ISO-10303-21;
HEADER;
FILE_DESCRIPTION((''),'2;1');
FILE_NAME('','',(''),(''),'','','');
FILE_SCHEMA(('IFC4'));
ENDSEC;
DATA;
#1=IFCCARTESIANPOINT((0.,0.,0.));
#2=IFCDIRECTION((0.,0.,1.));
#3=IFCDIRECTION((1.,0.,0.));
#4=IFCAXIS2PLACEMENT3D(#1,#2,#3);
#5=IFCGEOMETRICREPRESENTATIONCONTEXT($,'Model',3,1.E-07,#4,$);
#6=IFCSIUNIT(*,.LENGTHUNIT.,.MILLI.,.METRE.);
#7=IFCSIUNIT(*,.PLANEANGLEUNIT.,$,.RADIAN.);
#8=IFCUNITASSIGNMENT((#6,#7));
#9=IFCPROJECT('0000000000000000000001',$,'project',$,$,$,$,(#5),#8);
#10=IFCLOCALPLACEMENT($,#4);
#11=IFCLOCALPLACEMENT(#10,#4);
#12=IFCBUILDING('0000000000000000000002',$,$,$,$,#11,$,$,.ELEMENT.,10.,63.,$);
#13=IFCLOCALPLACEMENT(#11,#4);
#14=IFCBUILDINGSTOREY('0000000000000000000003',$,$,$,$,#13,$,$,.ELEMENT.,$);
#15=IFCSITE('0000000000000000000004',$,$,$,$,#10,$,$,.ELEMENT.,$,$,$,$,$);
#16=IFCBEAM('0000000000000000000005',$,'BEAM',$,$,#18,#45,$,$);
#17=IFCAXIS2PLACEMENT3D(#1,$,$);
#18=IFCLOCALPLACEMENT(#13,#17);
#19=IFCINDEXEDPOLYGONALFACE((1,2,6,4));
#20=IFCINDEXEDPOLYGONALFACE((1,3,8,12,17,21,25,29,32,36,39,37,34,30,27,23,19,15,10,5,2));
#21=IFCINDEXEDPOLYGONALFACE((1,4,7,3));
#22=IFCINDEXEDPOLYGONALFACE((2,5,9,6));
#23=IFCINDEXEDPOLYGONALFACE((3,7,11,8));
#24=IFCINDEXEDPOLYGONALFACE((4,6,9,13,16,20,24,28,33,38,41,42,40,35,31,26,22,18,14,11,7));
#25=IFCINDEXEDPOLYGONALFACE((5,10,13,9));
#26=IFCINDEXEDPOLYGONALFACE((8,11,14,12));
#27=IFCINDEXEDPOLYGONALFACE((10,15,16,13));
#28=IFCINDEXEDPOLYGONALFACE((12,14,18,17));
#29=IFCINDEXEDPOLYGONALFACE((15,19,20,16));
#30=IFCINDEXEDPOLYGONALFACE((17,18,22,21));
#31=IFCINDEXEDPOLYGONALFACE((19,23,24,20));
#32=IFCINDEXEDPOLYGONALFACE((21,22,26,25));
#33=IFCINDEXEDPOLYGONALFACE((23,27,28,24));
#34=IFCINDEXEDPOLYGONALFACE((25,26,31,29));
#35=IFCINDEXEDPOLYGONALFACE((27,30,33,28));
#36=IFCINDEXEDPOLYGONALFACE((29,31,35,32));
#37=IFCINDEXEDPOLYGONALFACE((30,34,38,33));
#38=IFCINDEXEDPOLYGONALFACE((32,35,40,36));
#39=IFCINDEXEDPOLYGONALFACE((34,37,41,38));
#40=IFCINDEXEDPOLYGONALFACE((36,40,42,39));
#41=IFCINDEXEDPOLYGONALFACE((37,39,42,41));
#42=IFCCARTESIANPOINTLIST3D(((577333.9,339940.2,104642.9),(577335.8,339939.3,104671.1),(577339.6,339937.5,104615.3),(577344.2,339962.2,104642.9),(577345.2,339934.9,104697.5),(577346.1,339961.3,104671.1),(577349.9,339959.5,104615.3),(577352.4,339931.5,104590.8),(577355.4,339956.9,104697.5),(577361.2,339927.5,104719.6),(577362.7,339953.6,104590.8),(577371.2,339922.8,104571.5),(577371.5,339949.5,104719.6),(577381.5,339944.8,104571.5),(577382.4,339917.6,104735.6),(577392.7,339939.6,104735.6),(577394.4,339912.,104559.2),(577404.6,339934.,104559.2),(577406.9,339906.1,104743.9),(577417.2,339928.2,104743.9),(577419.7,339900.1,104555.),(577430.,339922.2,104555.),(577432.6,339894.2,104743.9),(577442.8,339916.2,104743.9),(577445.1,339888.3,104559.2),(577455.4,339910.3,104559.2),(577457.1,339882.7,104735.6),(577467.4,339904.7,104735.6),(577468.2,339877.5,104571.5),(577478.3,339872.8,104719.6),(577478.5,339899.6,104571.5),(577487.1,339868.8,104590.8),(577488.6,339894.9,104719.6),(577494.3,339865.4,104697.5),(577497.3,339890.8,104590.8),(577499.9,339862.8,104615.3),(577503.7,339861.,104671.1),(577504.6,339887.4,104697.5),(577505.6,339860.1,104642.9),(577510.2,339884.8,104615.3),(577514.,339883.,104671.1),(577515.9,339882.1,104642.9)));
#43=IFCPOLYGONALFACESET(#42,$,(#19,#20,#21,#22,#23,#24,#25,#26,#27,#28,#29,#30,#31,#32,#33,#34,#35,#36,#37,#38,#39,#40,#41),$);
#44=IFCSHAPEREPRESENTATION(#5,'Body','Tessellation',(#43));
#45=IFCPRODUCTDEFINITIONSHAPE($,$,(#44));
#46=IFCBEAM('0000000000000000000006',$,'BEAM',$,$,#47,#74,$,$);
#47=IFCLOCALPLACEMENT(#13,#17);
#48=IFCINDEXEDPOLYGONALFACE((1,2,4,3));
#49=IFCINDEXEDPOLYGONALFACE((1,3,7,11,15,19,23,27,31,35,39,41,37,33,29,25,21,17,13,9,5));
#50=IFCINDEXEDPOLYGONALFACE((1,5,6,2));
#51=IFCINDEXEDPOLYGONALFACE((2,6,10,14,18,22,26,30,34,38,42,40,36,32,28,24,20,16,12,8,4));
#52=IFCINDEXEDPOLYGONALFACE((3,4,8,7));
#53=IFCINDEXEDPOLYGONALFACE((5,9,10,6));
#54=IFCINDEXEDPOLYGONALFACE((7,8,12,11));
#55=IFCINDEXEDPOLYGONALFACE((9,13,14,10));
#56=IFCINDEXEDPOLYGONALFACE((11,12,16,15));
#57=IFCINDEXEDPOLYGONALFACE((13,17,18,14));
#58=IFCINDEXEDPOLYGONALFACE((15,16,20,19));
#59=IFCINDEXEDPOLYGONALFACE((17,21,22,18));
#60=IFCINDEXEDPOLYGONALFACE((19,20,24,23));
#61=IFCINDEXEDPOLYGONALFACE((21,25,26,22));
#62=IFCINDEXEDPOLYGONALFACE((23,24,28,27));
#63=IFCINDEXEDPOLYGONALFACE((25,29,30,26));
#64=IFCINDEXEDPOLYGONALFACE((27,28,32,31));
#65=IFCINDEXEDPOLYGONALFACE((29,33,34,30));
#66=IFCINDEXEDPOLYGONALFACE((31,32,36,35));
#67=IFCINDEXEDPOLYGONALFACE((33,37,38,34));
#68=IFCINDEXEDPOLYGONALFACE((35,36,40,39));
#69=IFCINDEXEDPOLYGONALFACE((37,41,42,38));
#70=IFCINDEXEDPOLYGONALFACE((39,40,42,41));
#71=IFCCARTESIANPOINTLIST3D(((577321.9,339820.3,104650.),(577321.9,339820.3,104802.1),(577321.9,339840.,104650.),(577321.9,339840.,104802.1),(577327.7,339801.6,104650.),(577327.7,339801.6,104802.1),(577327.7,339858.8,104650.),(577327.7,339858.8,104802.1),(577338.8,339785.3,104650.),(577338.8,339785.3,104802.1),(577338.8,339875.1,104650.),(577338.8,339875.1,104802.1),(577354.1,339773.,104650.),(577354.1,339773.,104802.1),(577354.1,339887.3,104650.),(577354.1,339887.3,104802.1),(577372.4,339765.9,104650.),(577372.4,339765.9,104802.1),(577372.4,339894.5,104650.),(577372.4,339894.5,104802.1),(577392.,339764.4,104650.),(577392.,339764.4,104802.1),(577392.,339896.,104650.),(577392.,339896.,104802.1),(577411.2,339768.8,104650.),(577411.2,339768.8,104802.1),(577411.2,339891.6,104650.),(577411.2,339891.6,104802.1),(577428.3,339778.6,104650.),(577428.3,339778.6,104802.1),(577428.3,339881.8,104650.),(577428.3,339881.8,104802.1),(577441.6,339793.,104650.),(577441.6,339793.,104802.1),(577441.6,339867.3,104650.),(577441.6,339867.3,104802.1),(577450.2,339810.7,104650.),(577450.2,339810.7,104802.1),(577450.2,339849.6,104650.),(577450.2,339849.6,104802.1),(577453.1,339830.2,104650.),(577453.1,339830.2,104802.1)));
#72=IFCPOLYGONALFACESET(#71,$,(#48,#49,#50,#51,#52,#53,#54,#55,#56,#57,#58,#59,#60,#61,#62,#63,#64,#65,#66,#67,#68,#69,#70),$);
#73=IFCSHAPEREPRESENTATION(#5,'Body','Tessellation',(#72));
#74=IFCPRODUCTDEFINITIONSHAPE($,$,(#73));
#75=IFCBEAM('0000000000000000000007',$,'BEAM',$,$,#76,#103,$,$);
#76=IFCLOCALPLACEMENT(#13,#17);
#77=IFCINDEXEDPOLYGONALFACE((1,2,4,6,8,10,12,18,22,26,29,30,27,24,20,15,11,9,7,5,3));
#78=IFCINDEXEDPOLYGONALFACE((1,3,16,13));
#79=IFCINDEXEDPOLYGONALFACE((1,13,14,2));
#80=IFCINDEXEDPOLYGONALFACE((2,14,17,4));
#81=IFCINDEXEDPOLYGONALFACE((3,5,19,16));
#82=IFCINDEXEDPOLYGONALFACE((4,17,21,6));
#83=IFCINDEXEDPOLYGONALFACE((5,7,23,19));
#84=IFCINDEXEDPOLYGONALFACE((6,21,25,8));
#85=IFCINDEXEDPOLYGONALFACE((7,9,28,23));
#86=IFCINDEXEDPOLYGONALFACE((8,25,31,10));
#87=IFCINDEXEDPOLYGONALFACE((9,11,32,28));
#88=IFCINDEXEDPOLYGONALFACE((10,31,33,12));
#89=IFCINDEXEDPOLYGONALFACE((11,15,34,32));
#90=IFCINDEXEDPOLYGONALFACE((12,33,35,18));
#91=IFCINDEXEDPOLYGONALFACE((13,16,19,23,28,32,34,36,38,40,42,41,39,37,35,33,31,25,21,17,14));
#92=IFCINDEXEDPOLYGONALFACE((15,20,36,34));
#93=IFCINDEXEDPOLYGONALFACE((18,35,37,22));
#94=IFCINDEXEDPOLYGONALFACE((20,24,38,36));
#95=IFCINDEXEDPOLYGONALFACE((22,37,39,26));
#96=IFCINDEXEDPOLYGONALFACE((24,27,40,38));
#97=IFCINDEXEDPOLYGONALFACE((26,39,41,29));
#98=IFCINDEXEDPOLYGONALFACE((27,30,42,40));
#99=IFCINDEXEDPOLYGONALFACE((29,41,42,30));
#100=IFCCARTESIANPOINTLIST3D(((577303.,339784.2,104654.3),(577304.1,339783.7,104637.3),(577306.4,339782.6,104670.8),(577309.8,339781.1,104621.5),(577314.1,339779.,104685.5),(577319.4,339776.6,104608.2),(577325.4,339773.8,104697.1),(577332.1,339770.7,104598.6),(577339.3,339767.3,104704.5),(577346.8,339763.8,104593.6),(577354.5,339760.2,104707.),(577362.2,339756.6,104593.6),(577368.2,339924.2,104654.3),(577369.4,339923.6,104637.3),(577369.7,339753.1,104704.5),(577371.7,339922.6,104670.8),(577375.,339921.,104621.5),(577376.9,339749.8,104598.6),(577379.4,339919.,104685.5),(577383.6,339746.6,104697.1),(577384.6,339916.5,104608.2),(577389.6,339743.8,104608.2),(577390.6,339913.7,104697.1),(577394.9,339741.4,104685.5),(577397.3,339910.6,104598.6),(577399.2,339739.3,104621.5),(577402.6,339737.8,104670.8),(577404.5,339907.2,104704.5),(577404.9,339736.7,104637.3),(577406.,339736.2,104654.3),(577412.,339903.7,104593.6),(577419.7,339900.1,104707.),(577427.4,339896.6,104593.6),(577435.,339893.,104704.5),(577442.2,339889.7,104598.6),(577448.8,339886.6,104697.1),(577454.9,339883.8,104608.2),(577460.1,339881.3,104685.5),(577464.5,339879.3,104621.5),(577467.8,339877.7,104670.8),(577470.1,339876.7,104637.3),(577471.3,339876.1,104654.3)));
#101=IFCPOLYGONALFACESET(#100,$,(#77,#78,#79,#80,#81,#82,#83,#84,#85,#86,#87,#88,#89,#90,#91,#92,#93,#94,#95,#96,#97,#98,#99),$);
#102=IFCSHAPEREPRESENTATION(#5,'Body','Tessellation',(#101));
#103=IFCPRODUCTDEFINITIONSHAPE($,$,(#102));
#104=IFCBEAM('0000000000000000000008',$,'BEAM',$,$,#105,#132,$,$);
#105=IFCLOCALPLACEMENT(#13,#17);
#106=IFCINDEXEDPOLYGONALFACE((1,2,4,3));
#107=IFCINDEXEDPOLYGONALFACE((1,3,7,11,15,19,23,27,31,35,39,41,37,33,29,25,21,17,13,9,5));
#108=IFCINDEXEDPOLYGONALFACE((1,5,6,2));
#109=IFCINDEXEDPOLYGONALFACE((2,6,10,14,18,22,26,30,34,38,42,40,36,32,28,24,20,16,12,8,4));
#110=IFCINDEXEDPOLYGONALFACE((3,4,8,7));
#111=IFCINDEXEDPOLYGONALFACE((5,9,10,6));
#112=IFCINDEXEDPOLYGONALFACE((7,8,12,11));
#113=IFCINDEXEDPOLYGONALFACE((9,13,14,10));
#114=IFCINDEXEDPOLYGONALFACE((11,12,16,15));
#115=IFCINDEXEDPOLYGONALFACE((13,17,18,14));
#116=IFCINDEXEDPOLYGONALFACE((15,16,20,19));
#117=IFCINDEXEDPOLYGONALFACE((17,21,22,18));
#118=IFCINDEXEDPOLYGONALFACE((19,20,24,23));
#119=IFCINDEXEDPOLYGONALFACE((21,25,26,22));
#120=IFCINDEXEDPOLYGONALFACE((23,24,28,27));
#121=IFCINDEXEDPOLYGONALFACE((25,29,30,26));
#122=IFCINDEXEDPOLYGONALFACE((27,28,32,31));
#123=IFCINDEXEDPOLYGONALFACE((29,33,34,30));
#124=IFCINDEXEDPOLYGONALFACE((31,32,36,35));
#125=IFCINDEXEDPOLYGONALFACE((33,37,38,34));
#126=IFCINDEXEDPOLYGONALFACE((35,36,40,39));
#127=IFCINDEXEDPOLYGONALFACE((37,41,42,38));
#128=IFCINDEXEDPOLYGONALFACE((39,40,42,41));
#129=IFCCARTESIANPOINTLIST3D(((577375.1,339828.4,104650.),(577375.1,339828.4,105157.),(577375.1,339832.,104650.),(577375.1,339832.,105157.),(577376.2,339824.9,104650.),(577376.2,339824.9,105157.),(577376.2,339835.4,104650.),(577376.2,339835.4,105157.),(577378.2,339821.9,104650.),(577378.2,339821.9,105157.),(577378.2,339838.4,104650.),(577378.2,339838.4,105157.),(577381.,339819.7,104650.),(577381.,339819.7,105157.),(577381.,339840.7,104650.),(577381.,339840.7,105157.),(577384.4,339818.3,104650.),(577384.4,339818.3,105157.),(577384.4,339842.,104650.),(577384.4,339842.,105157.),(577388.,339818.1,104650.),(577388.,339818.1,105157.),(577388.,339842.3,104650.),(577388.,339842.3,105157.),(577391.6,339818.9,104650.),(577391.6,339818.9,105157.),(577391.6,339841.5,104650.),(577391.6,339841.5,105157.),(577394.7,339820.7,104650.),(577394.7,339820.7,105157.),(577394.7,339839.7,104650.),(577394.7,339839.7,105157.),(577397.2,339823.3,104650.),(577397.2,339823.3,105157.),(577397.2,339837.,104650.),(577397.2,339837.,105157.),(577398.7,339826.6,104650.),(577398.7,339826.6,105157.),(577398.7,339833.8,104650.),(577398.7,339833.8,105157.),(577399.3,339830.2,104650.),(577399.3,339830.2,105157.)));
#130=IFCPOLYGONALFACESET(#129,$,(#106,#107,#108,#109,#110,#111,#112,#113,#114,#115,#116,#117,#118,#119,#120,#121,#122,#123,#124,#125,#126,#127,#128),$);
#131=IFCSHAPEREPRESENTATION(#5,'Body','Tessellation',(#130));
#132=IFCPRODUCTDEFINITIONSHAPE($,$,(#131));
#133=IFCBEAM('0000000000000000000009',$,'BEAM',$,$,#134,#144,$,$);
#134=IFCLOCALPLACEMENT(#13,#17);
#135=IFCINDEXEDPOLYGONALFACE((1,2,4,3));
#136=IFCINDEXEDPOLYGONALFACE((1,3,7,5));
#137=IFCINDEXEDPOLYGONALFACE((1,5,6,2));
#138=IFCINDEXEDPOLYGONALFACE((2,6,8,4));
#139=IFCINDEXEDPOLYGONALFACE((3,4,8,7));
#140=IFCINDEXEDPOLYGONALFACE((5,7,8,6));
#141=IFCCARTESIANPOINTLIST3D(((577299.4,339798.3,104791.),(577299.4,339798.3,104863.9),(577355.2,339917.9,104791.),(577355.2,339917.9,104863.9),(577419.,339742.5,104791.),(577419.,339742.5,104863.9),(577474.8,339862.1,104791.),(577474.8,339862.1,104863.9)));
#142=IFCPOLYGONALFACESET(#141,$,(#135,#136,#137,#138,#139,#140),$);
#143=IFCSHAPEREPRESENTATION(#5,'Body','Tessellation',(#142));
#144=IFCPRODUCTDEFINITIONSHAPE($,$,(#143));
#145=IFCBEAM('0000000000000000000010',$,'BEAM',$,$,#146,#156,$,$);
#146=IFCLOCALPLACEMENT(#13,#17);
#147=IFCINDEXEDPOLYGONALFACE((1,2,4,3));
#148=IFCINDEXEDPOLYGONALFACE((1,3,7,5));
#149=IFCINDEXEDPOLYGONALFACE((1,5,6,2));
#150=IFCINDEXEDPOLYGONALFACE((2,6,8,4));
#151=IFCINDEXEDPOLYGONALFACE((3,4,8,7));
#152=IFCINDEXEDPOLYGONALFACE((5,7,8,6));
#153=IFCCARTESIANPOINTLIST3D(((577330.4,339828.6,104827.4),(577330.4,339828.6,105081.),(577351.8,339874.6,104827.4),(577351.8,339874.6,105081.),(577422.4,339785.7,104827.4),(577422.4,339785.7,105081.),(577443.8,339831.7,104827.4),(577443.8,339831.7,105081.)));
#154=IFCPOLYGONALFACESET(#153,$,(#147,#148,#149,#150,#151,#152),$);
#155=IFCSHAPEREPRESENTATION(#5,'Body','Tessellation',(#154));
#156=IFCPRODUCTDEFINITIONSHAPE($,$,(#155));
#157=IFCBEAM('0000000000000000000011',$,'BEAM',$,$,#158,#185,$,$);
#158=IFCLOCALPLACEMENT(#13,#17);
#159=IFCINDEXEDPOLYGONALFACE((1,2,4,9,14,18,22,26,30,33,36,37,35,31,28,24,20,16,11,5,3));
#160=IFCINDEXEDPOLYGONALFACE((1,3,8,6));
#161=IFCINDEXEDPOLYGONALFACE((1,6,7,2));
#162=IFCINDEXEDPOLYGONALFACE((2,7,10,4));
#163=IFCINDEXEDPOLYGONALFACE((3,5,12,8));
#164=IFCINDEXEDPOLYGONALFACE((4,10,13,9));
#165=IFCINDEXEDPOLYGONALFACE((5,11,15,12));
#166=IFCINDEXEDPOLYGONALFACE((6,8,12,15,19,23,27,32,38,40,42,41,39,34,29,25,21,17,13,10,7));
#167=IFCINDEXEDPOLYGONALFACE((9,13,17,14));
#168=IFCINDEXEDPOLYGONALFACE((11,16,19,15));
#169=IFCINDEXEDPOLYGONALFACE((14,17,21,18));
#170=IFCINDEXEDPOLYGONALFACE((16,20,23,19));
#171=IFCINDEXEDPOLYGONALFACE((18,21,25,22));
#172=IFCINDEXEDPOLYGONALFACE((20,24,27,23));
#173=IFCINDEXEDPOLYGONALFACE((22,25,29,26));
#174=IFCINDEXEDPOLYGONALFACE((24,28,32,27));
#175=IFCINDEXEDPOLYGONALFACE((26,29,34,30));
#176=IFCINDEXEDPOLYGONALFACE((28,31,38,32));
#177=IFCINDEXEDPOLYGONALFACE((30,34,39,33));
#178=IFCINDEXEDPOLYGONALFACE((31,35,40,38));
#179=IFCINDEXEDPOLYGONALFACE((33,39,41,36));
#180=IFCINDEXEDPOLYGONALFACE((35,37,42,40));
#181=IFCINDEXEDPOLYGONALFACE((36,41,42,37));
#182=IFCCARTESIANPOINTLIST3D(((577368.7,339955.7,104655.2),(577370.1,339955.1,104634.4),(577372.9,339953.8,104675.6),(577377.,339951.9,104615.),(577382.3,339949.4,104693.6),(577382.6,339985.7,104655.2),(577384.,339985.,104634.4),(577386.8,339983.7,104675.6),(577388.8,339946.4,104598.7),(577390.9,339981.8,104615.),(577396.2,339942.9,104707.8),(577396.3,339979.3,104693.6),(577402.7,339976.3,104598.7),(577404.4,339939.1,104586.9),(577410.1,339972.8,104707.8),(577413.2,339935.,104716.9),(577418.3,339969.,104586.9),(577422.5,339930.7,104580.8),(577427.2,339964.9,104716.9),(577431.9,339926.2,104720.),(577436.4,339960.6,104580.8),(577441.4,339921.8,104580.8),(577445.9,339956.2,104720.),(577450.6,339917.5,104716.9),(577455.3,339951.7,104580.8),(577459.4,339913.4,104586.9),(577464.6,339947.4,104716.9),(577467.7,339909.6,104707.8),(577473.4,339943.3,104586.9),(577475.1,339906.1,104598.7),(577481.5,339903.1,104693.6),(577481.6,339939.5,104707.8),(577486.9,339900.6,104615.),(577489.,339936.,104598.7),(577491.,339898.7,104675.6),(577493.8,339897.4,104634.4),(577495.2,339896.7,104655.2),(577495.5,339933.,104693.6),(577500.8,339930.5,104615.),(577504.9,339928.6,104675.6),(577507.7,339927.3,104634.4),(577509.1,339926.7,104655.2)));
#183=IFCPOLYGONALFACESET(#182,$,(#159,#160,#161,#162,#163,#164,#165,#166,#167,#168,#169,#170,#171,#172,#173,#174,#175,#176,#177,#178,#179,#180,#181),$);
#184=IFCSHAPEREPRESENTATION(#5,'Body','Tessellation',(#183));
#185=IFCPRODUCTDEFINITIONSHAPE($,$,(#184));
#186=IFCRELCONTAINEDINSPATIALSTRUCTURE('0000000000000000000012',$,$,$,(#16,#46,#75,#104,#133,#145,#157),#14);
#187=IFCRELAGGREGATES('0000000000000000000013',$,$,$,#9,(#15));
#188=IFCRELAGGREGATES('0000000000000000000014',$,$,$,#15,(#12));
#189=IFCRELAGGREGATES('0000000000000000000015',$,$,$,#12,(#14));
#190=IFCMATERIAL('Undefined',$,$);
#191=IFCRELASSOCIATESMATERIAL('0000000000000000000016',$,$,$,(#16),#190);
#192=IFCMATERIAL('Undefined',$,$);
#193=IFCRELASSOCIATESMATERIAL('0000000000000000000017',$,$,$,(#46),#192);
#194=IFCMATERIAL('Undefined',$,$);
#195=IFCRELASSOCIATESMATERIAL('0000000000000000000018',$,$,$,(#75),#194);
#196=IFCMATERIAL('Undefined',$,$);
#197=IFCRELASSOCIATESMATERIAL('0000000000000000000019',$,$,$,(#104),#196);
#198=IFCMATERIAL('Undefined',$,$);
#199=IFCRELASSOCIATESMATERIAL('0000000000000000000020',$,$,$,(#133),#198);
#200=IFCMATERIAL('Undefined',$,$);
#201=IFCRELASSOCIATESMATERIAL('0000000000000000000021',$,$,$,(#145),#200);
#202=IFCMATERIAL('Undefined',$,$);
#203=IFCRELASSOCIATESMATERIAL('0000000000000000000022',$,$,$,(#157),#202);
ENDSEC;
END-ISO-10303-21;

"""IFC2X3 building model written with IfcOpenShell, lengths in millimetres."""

from ifc_helpers import new_model, si_unit, frame, origin_with_axes, origin_2d_with_axis, place, context, project, spatial, rectangle, circle, extrude, material, element, save


model = new_model("IFC2X3")

# Units and contexts
model_context = context("Model", 3, precision=1e-07, world=origin_with_axes())
ifc_project = project(units=[si_unit("LENGTHUNIT", "METRE", prefix="MILLI"), si_unit("PLANEANGLEUNIT", "RADIAN")], contexts=[model_context])

# Site, building, storey
site_placement = place(None, origin_with_axes())
site = spatial("IfcSite", under=ifc_project, at=site_placement, CompositionType="ELEMENT")
building_placement = place(site_placement, origin_with_axes())
building = spatial("IfcBuilding", under=site, at=building_placement, CompositionType="ELEMENT", ElevationOfRefHeight=10.0, ElevationOfTerrain=63.0)
storey_placement = place(building_placement, origin_with_axes())
storey = spatial("IfcBuildingStorey", under=building, at=storey_placement, CompositionType="ELEMENT")

# Beams
ifc_material_1 = material(Name="Undefined")
beam_1_placement = place(storey_placement, frame((577424.9, 339911.2, 104650.0), z_axis=(0.422618, 0.906308, 0.0), x_axis=(-0.906308, 0.422618, 0.0)))
element("IfcBeam", 1, at=beam_1_placement, inside=storey, material=ifc_material_1, Name="BEAM", context=model_context, shape_type="SweptSolid", body=[
    extrude(circle(Radius=95.0, at=origin_2d_with_axis()), frame((0.0, 0.0, -12.2), z_axis=(0.0, 0.0, 1.0), x_axis=(0.0, -1.0, 0.0)), (0.0, 0.0, 1.0), 24.3),
])
ifc_material_2 = material(Name="Undefined")
beam_2_placement = place(storey_placement, frame((577387.1, 339830.2, 104726.1), z_axis=(0.0, 0.0, 1.0), x_axis=(0.0, 1.0, 0.0)))
element("IfcBeam", 2, at=beam_2_placement, inside=storey, material=ifc_material_2, Name="BEAM", context=model_context, shape_type="SweptSolid", body=[
    extrude(circle(Radius=66.0, at=origin_2d_with_axis()), frame((0.0, 0.0, -76.0), z_axis=(0.0, 0.0, 1.0), x_axis=(0.0, -1.0, 0.0)), (0.0, 0.0, 1.0), 152.1),
])
ifc_material_3 = material(Name="Undefined")
beam_3_placement = place(storey_placement, frame((577387.1, 339830.2, 104650.0), z_axis=(-0.422618, -0.906308, 0.0), x_axis=(-0.906308, 0.422618, 0.0)))
element("IfcBeam", 3, at=beam_3_placement, inside=storey, material=ifc_material_3, Name="BEAM", context=model_context, shape_type="SweptSolid", body=[
    extrude(circle(Radius=57.0, at=origin_2d_with_axis()), frame((0.0, 0.0, -77.2), z_axis=(0.0, 0.0, 1.0), x_axis=(0.0, -1.0, 0.0)), (0.0, 0.0, 1.0), 154.4),
])
ifc_material_4 = material(Name="Undefined")
beam_4_placement = place(storey_placement, frame((577387.1, 339830.2, 104903.5), z_axis=(0.0, 0.0, 1.0), x_axis=(0.0, 1.0, 0.0)))
element("IfcBeam", 4, at=beam_4_placement, inside=storey, material=ifc_material_4, Name="BEAM", context=model_context, shape_type="SweptSolid", body=[
    extrude(circle(Radius=12.2, at=origin_2d_with_axis()), frame((0.0, 0.0, -253.5), z_axis=(0.0, 0.0, 1.0), x_axis=(0.0, -1.0, 0.0)), (0.0, 0.0, 1.0), 507.0),
])
ifc_material_5 = material(Name="Undefined")
beam_5_placement = place(storey_placement, frame((577387.1, 339830.2, 104827.4), z_axis=(0.0, 0.0, 1.0), x_axis=(-0.906308, 0.422618, 0.0)))
element("IfcBeam", 5, at=beam_5_placement, inside=storey, material=ifc_material_5, Name="BEAM", context=model_context, shape_type="SweptSolid", body=[
    extrude(rectangle(XDim=131.9, YDim=131.9, at=origin_2d_with_axis()), frame((0.0, 0.0, -36.5), z_axis=(0.0, 0.0, 1.0), x_axis=(0.0, -1.0, 0.0)), (0.0, 0.0, 1.0), 72.9),
])
ifc_material_6 = material(Name="Undefined")
beam_6_placement = place(storey_placement, frame((577387.1, 339830.2, 104954.2), z_axis=(0.0, 0.0, 1.0), x_axis=(-0.906308, 0.422618, 0.0)))
element("IfcBeam", 6, at=beam_6_placement, inside=storey, material=ifc_material_6, Name="BEAM", context=model_context, shape_type="SweptSolid", body=[
    extrude(rectangle(XDim=50.8, YDim=101.5, at=origin_2d_with_axis()), frame((0.0, 0.0, -126.8), z_axis=(0.0, 0.0, 1.0), x_axis=(0.0, -1.0, 0.0)), (0.0, 0.0, 1.0), 253.5),
])
ifc_material_7 = material(Name="Undefined")
beam_7_placement = place(storey_placement, frame((577438.9, 339941.2, 104650.0), z_axis=(-0.422618, -0.906308, 0.0), x_axis=(-0.906308, 0.422618, 0.0)))
element("IfcBeam", 7, at=beam_7_placement, inside=storey, material=ifc_material_7, Name="BEAM", context=model_context, shape_type="SweptSolid", body=[
    extrude(circle(Radius=70.0, at=origin_2d_with_axis()), frame((0.0, 0.0, -16.5), z_axis=(0.0, 0.0, 1.0), x_axis=(0.0, -1.0, 0.0)), (0.0, 0.0, 1.0), 33.0),
])

save(model, "model.ifc")
